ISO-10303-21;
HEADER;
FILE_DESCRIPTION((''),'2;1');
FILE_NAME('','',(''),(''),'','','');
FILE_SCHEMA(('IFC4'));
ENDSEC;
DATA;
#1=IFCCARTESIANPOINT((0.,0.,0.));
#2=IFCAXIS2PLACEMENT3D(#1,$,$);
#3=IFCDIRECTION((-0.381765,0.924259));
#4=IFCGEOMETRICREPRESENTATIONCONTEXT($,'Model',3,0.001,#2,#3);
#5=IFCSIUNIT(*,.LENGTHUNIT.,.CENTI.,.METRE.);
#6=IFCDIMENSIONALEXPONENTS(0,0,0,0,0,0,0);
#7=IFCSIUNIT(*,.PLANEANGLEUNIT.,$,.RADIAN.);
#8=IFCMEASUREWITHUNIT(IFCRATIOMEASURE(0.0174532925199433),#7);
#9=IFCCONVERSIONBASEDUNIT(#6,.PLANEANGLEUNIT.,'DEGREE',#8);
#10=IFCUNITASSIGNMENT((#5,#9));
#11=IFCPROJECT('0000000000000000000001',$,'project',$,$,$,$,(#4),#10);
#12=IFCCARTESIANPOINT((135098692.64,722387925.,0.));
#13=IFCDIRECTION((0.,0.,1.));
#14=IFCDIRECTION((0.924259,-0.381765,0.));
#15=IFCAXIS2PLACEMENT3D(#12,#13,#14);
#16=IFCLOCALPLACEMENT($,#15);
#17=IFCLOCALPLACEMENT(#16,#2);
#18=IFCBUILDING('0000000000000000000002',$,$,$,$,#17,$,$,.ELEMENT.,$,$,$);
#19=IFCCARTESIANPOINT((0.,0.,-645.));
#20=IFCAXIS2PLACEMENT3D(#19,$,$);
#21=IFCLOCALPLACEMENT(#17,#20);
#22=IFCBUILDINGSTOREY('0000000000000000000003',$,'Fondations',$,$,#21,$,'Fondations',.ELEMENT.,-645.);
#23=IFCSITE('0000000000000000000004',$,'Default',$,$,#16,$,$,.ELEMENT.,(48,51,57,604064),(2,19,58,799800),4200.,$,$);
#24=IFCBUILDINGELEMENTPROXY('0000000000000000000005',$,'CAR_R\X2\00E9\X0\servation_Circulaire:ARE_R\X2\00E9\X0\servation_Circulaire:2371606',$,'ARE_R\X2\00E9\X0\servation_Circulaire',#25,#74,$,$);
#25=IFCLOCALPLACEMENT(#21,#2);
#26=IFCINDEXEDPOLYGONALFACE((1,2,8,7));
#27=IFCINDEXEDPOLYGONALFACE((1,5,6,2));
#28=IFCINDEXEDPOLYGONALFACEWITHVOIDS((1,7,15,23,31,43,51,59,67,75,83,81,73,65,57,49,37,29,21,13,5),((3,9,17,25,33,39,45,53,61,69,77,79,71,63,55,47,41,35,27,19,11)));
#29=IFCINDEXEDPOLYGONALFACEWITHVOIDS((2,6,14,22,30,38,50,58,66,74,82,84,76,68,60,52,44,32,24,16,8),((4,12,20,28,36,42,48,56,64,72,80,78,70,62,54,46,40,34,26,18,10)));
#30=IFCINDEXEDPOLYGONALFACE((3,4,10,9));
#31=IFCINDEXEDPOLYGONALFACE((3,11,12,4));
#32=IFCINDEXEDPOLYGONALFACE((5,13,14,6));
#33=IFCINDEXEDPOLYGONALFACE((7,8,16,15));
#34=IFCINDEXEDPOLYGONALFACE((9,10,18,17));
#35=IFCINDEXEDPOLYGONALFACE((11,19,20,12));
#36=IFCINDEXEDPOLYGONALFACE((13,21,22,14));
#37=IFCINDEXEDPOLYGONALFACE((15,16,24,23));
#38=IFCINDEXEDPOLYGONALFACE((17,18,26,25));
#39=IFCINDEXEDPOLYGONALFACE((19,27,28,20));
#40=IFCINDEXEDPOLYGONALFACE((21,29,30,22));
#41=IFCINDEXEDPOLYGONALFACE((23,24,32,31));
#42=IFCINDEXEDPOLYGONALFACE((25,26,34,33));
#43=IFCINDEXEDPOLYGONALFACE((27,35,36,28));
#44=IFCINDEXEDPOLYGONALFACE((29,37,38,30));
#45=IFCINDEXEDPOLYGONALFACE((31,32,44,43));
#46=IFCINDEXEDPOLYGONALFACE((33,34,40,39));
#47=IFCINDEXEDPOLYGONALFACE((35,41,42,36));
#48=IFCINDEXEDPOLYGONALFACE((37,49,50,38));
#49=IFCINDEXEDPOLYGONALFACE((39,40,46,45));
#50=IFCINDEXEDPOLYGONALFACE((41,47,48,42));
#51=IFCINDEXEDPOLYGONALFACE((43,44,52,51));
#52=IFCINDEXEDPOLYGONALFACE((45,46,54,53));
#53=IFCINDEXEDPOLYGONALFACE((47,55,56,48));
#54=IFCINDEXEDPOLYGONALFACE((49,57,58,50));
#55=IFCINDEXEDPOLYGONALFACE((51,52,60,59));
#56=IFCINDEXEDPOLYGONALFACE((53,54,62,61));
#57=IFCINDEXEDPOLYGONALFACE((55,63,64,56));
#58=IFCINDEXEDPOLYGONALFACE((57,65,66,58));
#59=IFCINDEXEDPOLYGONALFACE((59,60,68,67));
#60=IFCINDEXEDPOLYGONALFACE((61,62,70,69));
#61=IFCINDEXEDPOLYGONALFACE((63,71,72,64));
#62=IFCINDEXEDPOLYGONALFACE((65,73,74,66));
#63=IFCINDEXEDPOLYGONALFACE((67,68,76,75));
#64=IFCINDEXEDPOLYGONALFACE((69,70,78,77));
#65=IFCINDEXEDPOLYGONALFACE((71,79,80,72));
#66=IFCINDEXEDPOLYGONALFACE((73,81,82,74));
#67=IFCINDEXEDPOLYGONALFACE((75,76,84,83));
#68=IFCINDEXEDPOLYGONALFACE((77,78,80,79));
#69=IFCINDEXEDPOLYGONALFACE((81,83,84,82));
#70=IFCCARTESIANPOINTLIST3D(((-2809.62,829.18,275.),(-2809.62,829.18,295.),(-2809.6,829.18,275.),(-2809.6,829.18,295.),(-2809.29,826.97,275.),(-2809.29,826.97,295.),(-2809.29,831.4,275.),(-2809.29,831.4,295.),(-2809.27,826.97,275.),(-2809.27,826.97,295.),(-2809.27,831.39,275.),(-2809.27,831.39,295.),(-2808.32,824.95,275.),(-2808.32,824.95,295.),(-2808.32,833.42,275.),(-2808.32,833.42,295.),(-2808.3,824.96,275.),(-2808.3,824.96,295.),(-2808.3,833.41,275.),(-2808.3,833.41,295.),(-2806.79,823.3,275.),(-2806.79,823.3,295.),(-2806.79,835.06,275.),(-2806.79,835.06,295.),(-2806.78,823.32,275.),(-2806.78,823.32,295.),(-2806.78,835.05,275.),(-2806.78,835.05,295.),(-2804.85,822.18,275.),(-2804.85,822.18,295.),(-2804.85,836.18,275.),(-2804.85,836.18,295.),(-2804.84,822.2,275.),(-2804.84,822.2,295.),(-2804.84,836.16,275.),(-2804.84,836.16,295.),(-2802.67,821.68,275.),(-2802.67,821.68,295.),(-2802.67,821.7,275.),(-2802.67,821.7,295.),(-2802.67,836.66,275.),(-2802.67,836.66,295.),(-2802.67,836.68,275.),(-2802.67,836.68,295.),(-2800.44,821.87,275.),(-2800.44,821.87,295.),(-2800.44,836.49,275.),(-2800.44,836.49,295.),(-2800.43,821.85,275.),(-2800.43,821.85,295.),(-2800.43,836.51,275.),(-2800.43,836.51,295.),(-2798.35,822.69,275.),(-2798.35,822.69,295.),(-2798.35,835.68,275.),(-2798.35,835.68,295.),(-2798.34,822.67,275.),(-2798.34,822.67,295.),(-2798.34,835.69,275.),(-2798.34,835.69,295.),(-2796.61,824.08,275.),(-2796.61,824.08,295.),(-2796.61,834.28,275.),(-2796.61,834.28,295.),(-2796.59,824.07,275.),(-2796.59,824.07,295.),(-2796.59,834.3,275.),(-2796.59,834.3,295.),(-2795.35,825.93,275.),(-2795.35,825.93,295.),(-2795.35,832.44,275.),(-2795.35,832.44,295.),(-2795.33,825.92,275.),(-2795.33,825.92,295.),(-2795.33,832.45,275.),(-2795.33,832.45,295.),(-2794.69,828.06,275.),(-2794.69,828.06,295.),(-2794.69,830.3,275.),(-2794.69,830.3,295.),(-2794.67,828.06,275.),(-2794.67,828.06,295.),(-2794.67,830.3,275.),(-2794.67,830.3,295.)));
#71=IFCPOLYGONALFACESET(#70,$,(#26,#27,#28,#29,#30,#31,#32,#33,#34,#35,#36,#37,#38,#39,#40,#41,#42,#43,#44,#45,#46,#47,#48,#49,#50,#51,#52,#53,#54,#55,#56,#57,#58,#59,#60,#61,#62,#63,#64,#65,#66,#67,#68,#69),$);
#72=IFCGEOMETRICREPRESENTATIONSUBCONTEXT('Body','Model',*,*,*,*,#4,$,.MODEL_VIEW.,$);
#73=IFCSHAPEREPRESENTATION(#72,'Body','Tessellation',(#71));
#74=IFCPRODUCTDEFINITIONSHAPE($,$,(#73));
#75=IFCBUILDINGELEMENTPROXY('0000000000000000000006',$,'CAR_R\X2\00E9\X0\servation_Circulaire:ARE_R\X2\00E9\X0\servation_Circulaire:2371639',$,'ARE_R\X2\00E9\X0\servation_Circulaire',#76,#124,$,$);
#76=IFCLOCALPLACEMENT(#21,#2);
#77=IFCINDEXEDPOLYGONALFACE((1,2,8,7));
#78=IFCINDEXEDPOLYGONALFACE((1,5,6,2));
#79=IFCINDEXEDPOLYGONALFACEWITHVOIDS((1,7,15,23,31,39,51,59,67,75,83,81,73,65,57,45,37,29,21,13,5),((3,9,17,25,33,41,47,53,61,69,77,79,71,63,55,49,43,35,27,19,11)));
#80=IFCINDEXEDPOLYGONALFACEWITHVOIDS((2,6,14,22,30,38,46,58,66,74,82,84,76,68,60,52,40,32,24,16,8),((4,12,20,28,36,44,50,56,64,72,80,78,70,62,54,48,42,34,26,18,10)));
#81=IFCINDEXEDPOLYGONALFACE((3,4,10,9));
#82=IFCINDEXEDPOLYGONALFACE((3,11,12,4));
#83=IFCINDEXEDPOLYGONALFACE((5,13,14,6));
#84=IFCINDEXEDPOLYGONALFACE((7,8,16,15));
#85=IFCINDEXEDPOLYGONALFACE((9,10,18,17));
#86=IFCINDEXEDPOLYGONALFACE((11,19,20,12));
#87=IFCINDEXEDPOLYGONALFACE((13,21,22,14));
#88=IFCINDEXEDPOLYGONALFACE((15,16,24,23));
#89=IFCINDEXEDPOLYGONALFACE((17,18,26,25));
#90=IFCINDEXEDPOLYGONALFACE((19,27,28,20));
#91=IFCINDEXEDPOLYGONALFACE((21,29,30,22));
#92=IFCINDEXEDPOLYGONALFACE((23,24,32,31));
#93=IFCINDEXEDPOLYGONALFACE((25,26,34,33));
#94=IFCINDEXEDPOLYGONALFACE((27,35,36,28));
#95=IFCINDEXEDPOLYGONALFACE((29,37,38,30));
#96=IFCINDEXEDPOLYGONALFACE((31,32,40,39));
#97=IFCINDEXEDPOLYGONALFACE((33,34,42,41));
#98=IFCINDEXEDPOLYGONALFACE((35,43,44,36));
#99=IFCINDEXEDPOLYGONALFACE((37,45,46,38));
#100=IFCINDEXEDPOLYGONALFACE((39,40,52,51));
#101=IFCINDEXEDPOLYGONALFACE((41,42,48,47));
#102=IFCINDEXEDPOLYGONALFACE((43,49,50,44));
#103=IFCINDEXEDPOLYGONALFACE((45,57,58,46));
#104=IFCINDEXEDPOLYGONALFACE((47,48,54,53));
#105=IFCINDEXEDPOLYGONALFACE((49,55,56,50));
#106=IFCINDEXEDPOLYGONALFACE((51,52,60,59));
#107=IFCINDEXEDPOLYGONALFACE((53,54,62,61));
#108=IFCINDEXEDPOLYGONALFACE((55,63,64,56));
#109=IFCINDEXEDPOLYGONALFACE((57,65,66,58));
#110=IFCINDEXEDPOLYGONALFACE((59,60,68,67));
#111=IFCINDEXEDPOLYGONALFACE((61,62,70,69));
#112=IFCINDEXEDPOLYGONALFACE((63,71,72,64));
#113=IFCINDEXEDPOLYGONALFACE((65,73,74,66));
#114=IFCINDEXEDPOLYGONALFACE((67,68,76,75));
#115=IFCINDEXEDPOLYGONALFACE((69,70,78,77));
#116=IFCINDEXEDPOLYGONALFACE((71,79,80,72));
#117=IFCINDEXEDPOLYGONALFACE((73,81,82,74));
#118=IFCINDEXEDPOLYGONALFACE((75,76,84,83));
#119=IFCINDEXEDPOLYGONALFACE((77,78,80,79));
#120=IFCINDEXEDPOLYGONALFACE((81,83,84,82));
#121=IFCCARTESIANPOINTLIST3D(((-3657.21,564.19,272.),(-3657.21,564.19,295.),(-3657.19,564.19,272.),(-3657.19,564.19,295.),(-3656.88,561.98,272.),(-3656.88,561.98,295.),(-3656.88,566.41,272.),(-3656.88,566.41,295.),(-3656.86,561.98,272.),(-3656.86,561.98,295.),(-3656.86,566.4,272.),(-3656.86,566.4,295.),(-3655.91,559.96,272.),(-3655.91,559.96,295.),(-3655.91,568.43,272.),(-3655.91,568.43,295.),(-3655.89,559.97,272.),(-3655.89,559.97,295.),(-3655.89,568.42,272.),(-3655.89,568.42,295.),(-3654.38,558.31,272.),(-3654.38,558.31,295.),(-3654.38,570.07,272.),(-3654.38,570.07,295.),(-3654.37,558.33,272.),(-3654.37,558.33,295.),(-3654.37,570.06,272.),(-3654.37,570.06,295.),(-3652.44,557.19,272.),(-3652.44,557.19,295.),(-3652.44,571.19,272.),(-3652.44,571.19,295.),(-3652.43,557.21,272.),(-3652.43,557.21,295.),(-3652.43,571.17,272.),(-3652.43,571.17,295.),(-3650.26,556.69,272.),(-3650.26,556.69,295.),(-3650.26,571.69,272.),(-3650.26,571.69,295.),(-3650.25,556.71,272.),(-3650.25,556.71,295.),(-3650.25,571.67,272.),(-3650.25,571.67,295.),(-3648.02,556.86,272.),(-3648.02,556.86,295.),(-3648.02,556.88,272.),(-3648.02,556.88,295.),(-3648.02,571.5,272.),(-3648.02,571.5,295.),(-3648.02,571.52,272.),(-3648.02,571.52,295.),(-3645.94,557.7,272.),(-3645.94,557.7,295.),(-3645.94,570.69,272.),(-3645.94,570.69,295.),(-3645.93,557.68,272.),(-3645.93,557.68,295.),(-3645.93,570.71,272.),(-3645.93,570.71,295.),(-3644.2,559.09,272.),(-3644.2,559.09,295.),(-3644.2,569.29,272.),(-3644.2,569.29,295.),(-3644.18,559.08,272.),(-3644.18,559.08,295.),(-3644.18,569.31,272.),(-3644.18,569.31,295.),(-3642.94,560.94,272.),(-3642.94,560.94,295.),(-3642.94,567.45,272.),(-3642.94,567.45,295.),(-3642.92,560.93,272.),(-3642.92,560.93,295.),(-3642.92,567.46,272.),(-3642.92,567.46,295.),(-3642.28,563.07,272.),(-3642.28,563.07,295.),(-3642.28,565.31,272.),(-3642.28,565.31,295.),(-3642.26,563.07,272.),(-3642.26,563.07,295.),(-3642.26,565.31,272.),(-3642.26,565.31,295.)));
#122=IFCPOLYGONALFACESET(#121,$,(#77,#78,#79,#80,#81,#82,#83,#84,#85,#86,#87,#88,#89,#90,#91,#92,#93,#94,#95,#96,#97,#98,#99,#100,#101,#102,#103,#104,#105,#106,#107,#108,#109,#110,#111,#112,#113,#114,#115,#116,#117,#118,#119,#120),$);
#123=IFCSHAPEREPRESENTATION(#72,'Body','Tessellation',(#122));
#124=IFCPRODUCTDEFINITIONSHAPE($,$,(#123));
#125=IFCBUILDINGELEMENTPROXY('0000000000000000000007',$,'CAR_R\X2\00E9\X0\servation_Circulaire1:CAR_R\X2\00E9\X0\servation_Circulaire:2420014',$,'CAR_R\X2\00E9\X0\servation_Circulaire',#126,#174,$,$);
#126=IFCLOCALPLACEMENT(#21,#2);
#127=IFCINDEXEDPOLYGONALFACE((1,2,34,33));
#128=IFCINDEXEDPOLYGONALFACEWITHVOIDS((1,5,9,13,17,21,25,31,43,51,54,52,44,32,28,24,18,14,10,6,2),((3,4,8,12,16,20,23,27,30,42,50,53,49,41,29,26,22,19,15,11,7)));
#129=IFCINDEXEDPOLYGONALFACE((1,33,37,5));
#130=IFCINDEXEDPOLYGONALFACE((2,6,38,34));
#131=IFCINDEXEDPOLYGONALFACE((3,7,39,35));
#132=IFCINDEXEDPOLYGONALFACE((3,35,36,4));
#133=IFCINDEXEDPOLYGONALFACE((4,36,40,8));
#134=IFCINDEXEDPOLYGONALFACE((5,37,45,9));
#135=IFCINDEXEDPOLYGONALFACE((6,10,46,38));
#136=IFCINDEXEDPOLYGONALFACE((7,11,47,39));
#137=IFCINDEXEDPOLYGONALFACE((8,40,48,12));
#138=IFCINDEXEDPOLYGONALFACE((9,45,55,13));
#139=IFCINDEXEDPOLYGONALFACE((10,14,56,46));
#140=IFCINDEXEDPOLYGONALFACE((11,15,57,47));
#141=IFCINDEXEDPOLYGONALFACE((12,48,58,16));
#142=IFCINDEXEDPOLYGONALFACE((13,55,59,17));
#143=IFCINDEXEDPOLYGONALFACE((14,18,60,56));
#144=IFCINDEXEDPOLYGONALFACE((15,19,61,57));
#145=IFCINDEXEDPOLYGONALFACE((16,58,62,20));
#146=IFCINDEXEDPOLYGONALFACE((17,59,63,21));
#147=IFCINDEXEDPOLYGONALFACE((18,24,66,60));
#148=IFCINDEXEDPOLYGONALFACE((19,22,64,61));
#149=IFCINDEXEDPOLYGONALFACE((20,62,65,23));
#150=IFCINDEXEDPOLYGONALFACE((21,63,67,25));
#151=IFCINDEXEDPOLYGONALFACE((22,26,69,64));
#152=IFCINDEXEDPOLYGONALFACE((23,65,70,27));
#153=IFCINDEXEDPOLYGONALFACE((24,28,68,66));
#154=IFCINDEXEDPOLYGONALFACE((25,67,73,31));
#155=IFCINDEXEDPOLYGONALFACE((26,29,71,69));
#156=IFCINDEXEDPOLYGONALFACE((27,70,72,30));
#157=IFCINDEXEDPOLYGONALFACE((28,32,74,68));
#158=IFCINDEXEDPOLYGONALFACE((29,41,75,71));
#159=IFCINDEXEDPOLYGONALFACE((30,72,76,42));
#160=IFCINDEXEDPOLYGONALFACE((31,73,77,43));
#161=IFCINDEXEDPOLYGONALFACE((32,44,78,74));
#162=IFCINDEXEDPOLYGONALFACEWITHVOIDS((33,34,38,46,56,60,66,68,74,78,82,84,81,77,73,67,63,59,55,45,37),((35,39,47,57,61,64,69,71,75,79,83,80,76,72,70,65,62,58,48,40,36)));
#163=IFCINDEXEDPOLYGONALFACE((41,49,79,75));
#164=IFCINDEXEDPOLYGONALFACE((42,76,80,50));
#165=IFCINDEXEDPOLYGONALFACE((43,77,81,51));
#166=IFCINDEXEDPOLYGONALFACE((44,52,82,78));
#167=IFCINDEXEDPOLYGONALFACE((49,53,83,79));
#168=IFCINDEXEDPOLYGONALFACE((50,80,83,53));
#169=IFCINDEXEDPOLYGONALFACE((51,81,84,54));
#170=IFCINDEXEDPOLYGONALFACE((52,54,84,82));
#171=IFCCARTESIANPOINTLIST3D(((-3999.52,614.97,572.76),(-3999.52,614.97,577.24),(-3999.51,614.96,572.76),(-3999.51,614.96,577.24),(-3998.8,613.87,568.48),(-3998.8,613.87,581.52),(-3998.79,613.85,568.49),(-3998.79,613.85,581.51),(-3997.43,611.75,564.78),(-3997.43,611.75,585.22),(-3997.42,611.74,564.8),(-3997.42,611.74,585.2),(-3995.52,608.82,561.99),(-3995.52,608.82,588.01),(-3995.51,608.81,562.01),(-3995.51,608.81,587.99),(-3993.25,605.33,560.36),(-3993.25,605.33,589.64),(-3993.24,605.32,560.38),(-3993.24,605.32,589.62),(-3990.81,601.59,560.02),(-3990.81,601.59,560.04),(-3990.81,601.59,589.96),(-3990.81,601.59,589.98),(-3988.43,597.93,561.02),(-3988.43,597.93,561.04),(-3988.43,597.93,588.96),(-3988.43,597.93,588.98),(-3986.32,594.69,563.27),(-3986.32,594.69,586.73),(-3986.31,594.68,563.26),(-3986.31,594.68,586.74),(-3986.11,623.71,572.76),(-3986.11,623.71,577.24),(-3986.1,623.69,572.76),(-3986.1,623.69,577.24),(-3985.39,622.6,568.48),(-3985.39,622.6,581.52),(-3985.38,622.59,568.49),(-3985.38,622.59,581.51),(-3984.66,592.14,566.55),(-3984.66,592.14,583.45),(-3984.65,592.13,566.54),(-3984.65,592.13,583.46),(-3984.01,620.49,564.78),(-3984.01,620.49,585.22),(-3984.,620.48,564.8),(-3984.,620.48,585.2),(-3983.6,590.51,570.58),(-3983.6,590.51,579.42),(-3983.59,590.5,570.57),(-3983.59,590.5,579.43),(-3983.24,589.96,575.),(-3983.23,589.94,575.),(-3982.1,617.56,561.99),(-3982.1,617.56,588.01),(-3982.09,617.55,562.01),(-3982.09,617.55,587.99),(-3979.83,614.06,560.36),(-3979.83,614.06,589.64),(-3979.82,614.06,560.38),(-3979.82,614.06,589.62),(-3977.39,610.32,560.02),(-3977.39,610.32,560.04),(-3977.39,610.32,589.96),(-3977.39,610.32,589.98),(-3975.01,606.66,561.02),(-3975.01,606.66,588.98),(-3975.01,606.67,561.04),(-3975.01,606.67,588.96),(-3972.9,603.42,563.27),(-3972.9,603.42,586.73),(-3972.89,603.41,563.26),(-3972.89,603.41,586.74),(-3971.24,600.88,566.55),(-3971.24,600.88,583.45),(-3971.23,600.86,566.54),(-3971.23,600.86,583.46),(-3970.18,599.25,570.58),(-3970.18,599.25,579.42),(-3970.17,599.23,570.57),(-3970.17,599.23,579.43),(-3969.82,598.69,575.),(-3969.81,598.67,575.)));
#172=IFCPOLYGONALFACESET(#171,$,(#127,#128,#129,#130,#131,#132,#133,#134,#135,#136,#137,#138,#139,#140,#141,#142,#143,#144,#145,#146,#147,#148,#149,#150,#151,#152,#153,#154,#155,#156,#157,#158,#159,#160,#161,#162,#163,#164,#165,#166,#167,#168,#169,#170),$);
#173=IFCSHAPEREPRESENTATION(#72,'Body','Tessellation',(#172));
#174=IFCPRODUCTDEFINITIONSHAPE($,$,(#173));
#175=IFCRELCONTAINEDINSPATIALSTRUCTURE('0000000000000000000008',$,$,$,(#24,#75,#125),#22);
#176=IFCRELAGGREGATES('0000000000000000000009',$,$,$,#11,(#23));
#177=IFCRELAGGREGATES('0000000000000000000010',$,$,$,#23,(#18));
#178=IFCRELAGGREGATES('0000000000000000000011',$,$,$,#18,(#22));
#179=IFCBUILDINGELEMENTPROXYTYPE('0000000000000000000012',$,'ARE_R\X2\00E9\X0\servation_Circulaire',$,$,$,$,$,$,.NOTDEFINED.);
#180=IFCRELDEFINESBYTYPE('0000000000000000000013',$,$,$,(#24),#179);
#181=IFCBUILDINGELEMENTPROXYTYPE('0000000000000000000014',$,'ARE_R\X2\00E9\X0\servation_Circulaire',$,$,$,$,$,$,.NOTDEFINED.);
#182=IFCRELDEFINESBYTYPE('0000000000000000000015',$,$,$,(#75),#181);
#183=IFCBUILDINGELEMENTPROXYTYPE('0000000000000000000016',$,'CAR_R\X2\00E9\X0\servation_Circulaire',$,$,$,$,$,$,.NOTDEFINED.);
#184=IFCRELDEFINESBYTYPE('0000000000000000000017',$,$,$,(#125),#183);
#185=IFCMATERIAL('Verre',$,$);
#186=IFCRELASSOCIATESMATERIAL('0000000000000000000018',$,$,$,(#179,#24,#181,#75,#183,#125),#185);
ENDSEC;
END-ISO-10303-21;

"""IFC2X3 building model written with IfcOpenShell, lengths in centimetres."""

from ifc_helpers import new_model, entity, si_unit, converted_unit, direction, frame, frame_2d, origin, place, context, subcontext, project, spatial, hollow_circle, extrude, source, transform, mapped, material, type_object, type_shapes, element, save


model = new_model("IFC2X3")

# Units and contexts
model_context = context("Model", 3, precision=0.001, world=origin(), true_north=direction((-0.381765, 0.924259)))
body_context = subcontext(model_context, "Body", "Model", "MODEL_VIEW")
ifc_project = project(units=[si_unit("LENGTHUNIT", "METRE", prefix="CENTI"), converted_unit("PLANEANGLEUNIT", "DEGREE", entity("IfcRatioMeasure", 0.0174532925199433), si_unit("PLANEANGLEUNIT", "RADIAN"), dimensions=[0, 0, 0, 0, 0, 0, 0])], contexts=[model_context])

# Site, building, storey
site_placement = place(None, frame((135098692.64, 722387925.0, 0.0), z_axis=(0.0, 0.0, 1.0), x_axis=(0.924259, -0.381765, 0.0)))
site = spatial("IfcSite", under=ifc_project, at=site_placement, Name="Default", CompositionType="ELEMENT", RefLatitude=(48, 51, 57, 604064), RefLongitude=(2, 19, 58, 799800), RefElevation=4200.0)
building_placement = place(site_placement, origin())
building = spatial("IfcBuilding", under=site, at=building_placement, CompositionType="ELEMENT")
storey_placement = place(building_placement, frame((0.0, 0.0, -645.0)))
storey = spatial("IfcBuildingStorey", under=building, at=storey_placement, Name="Fondations", LongName="Fondations", CompositionType="ELEMENT", Elevation=-645.0)

# Building element proxies
ifc_material_1 = material(Name="Verre")
building_element_proxy_type_1 = type_object("IfcBuildingElementProxyType", Name="ARE_Réservation_Circulaire", PredefinedType="NOTDEFINED", material=ifc_material_1)
shared_shape_1 = source(origin(), body_context, "Body", "SweptSolid", [
    extrude(hollow_circle(Radius=7.52, WallThickness=0.02, at=frame_2d((0.0, 0.0), x_axis=(1.0, 0.0))), frame((0.0, 0.0, -20.0)), (0.0, 0.0, 1.0), 20.0),
])
type_shapes(building_element_proxy_type_1, [shared_shape_1])
for number, where, z_axis, x_axis, name in (
    (1, (-2802.1, 829.18, 295.0), (0.0, 0.0, 1.0), (-1.0, 0.0, 0.0), "CAR_Réservation_Circulaire:ARE_Réservation_Circulaire:2371606"),
):
    element("IfcBuildingElementProxy", number, at=place(storey_placement, frame(where, z_axis=z_axis, x_axis=x_axis)), inside=storey, type_object=building_element_proxy_type_1, material=ifc_material_1, Name=name, ObjectType="ARE_Réservation_Circulaire", context=body_context, shape_type="MappedRepresentation", body=[
        mapped(shared_shape_1, transform((0.0, 0.0, 0.0), scale=1.0)),
    ])
building_element_proxy_type_2 = type_object("IfcBuildingElementProxyType", Name="ARE_Réservation_Circulaire", PredefinedType="NOTDEFINED", material=ifc_material_1)
shared_shape_2 = source(origin(), body_context, "Body", "SweptSolid", [
    extrude(hollow_circle(Radius=7.52, WallThickness=0.02, at=frame_2d((0.0, 0.0), x_axis=(1.0, 0.0))), frame((0.0, 0.0, -23.0)), (0.0, 0.0, 1.0), 23.0),
])
type_shapes(building_element_proxy_type_2, [shared_shape_2])
proxy_1_placement = place(storey_placement, frame((-3649.69, 564.19, 295.0), z_axis=(0.0, 0.0, 1.0), x_axis=(-1.0, 0.0, 0.0)))
element("IfcBuildingElementProxy", 2, at=proxy_1_placement, inside=storey, type_object=building_element_proxy_type_2, material=ifc_material_1, Name="CAR_Réservation_Circulaire:ARE_Réservation_Circulaire:2371639", ObjectType="ARE_Réservation_Circulaire", context=body_context, shape_type="MappedRepresentation", body=[
    mapped(shared_shape_2, transform((0.0, 0.0, 0.0), scale=1.0)),
])
building_element_proxy_type_3 = type_object("IfcBuildingElementProxyType", Name="CAR_Réservation_Circulaire", PredefinedType="NOTDEFINED", material=ifc_material_1)
shared_shape_3 = source(origin(), body_context, "Body", "SweptSolid", [
    extrude(hollow_circle(Radius=15.02, WallThickness=0.02, at=frame_2d((0.0, 0.0), x_axis=(1.0, 0.0))), frame((0.0, 0.0, -15.0)), (0.0, 0.0, 1.0), 16.01),
])
type_shapes(building_element_proxy_type_3, [shared_shape_3])
proxy_2_placement = place(storey_placement, frame((-3990.57, 603.08, 575.0), z_axis=(-0.83808, -0.545548, 0.0), x_axis=(0.545548, -0.83808, 0.0)))
element("IfcBuildingElementProxy", 3, at=proxy_2_placement, inside=storey, type_object=building_element_proxy_type_3, material=ifc_material_1, Name="CAR_Réservation_Circulaire1:CAR_Réservation_Circulaire:2420014", ObjectType="CAR_Réservation_Circulaire", context=body_context, shape_type="MappedRepresentation", body=[
    mapped(shared_shape_3, transform((0.0, 0.0, 0.0), scale=1.0)),
])

save(model, "model.ifc")
